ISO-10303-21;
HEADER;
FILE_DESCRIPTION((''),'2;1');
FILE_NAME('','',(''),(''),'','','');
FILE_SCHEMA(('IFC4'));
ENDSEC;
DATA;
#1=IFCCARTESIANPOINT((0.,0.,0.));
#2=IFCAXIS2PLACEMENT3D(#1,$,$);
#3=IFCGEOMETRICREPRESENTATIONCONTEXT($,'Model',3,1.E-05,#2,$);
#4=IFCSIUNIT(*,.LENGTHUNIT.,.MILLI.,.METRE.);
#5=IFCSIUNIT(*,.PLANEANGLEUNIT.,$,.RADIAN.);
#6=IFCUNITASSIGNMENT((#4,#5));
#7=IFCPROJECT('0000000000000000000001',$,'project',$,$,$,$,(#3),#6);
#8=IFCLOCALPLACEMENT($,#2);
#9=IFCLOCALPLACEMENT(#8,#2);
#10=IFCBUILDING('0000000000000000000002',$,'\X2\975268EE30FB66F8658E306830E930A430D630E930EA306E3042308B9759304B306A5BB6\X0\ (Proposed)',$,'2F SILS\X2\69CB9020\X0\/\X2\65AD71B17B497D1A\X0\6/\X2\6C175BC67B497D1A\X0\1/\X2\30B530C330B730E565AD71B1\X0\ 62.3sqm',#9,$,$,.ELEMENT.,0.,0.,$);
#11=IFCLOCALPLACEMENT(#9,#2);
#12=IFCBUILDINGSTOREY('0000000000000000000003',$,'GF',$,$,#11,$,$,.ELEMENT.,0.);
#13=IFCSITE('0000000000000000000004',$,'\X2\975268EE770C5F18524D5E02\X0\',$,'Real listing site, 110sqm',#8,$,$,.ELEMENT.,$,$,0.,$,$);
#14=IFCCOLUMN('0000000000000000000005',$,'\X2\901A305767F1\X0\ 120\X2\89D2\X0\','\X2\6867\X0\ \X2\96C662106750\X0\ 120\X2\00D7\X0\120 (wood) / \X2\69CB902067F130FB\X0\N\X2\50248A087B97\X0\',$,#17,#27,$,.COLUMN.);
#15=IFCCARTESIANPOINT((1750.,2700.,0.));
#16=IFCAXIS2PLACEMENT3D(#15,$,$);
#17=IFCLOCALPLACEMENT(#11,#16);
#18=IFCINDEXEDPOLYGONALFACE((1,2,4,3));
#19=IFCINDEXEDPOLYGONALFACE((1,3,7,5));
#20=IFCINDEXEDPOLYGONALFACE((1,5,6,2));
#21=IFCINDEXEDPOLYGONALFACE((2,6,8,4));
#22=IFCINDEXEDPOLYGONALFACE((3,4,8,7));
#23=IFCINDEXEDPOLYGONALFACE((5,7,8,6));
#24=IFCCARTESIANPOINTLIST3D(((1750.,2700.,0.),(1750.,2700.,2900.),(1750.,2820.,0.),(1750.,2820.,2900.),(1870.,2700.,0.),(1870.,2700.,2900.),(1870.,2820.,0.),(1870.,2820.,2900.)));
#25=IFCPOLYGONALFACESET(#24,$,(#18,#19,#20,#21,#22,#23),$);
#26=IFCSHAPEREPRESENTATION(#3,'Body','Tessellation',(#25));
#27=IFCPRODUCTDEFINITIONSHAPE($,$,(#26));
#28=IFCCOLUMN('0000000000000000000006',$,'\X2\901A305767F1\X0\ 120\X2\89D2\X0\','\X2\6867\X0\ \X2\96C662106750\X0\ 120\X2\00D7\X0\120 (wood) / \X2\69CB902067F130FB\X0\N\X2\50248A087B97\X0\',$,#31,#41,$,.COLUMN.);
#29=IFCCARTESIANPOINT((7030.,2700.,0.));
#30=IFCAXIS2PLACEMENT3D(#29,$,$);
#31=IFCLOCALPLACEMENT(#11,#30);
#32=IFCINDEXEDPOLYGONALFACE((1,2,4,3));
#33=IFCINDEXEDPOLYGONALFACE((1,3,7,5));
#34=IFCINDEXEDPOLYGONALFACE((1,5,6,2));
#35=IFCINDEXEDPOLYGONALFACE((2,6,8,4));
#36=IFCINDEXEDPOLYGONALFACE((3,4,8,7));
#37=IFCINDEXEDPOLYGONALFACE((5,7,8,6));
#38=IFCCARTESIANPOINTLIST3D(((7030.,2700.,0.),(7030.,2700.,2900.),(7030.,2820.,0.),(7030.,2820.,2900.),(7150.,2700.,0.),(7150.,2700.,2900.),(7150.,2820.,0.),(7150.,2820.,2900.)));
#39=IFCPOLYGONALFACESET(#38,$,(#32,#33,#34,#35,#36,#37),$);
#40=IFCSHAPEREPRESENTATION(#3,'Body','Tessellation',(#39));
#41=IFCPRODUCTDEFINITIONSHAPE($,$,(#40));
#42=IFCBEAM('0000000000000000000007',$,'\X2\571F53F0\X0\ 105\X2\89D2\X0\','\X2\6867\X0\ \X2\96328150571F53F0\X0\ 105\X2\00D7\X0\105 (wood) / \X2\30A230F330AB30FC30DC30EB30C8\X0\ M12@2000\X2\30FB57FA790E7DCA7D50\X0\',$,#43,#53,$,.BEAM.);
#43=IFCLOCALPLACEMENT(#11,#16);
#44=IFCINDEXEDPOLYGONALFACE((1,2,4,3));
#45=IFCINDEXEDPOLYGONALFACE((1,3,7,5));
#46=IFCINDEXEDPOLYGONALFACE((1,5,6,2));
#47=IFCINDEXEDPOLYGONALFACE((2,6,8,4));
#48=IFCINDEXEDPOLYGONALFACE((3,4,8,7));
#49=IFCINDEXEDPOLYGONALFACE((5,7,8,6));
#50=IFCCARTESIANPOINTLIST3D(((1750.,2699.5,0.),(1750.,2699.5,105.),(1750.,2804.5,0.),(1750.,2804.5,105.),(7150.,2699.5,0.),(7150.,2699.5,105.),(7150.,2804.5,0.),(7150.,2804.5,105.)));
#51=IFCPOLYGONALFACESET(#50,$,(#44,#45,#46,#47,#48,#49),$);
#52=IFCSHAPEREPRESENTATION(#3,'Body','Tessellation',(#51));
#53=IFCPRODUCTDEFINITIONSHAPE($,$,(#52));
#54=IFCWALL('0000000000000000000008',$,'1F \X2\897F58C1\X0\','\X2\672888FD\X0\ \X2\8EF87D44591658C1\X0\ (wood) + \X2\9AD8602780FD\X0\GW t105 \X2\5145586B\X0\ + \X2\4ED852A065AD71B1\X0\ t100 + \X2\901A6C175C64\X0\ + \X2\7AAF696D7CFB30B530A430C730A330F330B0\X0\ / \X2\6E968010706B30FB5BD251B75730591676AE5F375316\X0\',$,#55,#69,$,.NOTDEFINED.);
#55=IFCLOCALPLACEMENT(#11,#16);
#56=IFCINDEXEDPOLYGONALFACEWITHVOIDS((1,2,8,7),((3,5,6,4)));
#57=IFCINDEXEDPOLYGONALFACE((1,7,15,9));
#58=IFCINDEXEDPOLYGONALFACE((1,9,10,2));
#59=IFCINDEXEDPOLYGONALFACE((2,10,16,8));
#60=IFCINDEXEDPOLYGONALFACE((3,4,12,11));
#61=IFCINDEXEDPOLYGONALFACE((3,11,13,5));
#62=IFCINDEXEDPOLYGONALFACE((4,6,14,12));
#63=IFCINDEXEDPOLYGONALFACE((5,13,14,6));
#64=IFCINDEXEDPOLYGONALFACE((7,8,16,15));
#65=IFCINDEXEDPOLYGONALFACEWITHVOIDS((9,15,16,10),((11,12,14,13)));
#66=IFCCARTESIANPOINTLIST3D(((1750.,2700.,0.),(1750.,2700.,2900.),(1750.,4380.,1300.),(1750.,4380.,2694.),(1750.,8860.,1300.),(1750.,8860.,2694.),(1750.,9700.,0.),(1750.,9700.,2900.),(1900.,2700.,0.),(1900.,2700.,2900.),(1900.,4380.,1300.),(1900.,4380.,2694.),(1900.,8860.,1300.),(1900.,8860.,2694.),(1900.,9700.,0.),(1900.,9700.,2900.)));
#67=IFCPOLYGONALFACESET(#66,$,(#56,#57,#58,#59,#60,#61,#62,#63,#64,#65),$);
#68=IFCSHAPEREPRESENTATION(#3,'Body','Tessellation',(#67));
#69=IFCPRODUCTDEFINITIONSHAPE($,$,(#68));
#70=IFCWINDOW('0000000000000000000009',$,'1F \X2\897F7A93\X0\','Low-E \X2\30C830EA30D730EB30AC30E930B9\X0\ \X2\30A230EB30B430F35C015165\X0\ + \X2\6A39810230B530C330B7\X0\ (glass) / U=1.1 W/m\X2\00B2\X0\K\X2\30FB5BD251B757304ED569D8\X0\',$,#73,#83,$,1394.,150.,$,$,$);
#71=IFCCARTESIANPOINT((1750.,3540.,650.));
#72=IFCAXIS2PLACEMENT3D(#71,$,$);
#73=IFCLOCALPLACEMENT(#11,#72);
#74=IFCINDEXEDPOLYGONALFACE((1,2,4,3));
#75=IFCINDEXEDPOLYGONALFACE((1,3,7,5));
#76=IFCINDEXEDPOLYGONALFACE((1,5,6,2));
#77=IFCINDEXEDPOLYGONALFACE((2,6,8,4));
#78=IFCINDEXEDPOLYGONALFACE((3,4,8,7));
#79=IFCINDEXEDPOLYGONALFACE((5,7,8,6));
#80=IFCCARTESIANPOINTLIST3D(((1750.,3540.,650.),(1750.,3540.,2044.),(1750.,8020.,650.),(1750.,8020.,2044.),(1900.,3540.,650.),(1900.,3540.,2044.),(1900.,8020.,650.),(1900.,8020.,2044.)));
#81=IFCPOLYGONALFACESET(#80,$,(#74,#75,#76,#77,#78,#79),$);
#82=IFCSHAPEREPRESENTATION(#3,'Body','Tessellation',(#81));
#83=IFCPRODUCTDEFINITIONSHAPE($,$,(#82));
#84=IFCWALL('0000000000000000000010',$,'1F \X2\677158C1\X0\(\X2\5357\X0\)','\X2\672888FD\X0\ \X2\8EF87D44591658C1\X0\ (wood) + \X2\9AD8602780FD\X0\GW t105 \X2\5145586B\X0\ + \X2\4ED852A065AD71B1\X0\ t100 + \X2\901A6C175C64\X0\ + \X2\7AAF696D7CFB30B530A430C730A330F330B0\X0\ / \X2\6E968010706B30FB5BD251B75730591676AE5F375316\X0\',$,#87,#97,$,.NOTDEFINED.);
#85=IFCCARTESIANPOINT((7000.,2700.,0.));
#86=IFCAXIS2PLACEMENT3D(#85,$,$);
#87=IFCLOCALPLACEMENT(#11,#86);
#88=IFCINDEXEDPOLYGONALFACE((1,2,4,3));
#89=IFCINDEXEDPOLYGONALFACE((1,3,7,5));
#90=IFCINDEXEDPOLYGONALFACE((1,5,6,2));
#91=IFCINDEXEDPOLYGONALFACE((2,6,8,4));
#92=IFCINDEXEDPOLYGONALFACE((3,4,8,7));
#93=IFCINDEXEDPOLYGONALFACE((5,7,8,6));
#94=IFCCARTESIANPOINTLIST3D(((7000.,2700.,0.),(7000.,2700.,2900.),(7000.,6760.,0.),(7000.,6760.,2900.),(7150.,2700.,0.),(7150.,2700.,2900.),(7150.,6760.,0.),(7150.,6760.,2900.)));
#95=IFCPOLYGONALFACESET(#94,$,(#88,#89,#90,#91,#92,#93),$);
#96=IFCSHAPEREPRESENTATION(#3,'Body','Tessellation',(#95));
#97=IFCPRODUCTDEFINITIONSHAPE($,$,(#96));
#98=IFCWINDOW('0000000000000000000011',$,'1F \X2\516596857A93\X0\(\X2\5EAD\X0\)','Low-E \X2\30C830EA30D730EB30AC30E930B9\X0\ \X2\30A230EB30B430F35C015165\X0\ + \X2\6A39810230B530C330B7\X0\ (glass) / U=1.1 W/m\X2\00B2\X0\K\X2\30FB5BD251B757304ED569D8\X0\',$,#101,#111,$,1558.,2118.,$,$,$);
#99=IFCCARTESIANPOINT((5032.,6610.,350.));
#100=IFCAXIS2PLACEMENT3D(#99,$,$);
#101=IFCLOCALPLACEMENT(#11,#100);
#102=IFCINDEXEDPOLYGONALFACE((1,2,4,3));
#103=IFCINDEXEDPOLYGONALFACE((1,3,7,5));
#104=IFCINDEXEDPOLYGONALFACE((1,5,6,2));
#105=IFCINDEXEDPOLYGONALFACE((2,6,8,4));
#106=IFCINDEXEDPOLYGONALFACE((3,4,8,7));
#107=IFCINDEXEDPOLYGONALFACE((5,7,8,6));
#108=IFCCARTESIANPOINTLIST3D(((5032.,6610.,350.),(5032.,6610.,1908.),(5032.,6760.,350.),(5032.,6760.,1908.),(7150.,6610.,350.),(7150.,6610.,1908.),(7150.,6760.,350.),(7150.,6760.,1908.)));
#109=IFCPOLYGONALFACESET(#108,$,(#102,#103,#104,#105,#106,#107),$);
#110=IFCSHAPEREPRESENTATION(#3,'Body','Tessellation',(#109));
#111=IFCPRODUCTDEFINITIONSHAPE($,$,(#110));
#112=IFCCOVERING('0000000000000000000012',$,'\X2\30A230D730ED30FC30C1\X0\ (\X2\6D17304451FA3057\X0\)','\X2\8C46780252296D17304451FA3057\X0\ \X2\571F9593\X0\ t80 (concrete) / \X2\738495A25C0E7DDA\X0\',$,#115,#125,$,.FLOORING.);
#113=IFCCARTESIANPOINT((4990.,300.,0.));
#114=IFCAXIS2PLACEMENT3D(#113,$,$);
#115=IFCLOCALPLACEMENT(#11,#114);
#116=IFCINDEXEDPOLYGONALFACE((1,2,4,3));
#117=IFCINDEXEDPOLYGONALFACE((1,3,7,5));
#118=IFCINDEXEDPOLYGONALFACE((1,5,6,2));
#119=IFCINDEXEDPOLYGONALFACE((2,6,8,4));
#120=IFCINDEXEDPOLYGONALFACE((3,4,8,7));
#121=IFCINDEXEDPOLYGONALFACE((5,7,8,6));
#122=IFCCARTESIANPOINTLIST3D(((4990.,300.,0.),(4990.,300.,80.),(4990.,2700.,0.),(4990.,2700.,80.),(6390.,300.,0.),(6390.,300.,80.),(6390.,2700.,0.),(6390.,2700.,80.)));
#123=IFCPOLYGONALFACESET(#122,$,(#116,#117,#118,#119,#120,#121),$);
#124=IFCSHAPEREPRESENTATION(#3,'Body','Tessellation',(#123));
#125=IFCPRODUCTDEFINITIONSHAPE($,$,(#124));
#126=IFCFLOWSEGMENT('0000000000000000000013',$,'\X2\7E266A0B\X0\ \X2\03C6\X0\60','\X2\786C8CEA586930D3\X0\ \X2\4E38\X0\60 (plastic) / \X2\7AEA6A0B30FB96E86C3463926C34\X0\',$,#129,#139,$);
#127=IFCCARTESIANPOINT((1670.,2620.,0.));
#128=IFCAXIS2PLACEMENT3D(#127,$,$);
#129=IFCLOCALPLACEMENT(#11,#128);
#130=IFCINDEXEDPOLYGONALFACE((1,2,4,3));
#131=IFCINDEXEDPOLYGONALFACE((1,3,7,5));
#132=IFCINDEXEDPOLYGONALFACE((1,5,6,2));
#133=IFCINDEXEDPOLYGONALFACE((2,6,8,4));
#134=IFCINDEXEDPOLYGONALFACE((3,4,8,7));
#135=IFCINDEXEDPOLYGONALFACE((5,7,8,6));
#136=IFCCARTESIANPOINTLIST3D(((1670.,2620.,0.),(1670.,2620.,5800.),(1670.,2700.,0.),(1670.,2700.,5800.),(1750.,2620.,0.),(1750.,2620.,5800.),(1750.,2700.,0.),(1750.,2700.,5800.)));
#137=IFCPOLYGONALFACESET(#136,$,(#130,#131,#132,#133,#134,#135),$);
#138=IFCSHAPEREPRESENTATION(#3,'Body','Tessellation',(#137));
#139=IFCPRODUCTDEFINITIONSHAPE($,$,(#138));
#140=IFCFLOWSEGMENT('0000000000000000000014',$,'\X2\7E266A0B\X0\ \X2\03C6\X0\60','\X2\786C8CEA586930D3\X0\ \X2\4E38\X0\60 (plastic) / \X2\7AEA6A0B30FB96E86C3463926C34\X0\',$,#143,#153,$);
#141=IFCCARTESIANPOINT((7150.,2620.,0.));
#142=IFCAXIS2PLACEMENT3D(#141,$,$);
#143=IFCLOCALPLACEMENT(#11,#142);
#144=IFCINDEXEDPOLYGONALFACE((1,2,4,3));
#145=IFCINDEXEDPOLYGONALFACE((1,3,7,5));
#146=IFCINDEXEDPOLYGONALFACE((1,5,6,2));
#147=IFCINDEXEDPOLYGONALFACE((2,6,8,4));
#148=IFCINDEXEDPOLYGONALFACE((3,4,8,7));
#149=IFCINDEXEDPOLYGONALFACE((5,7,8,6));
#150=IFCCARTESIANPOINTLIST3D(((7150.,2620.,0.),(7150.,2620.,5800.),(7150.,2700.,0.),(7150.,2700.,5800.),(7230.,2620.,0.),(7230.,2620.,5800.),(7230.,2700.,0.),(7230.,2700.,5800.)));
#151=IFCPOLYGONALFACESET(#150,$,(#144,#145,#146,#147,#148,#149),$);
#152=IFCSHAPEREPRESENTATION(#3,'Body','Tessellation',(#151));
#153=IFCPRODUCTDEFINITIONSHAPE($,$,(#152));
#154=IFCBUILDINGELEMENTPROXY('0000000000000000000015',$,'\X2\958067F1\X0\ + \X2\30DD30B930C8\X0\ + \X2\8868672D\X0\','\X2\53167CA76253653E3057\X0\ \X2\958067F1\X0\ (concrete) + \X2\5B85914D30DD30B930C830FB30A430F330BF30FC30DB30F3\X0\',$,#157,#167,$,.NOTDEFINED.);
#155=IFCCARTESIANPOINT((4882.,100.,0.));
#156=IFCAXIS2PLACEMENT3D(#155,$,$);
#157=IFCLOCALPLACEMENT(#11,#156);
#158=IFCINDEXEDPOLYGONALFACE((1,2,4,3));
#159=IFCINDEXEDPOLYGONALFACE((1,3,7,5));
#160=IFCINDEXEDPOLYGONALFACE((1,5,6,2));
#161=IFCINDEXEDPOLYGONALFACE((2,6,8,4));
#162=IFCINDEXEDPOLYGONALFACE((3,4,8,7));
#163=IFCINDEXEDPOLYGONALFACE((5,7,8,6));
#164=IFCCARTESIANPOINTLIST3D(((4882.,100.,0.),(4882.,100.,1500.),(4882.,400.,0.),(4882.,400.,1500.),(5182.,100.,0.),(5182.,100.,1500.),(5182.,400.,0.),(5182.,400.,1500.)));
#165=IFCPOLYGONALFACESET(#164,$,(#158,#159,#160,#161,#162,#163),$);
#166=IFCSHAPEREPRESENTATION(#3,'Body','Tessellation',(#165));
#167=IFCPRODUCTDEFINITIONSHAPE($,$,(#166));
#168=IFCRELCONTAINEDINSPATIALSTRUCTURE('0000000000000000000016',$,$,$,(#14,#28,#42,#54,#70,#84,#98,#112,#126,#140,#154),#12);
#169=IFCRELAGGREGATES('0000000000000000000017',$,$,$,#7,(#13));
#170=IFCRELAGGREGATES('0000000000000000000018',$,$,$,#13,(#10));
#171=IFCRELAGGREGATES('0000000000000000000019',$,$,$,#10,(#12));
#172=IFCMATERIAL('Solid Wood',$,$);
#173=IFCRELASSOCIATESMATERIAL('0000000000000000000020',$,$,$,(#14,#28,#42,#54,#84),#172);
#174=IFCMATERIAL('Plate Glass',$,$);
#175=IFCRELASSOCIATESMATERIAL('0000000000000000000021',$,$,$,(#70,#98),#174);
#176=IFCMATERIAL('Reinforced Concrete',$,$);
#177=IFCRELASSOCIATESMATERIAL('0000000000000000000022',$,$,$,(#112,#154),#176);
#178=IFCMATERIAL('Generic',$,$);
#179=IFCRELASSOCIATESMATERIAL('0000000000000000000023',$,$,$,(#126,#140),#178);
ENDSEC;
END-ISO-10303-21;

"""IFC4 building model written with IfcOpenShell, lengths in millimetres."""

from ifc_helpers import new_model, si_unit, frame, frame_2d, origin, place, context, project, spatial, rectangle, extrude, material, element, fill, save


model = new_model("IFC4")

# Units and contexts
model_context = context("Model", 3, precision=1e-05, world=origin())
ifc_project = project(units=[si_unit("LENGTHUNIT", "METRE", prefix="MILLI"), si_unit("PLANEANGLEUNIT", "RADIAN")], contexts=[model_context])

# Site, building, storey
site_placement = place(None, origin())
site = spatial("IfcSite", under=ifc_project, at=site_placement, Name="青森県弘前市", ObjectType="Real listing site, 110sqm", CompositionType="ELEMENT", RefElevation=0.0)
building_placement = place(site_placement, origin())
building = spatial("IfcBuilding", under=site, at=building_placement, Name="青森・書斎とライブラリのある静かな家 (Proposed)", ObjectType="2F SILS構造/断熱等級6/気密等級1/サッシュ断熱 62.3sqm", CompositionType="ELEMENT", ElevationOfRefHeight=0.0, ElevationOfTerrain=0.0)
storey_placement = place(building_placement, origin())
storey = spatial("IfcBuildingStorey", under=building, at=storey_placement, Name="GF", CompositionType="ELEMENT", Elevation=0.0)

# Columns
ifc_material_1 = material(Name="Solid Wood")
column_1_placement = place(storey_placement, frame((1750.0, 2700.0, 0.0)))
element("IfcColumn", 1, at=column_1_placement, inside=storey, material=ifc_material_1, Name="通し柱 120角", Description="桧 集成材 120×120 (wood) / 構造柱・N値計算", PredefinedType="COLUMN", context=model_context, shape_type="SweptSolid", body=[
    extrude(rectangle(XDim=120.0, YDim=120.0, at=frame_2d((60.0, 60.0))), frame((1750.0, 2700.0, 0.0)), (0.0, 0.0, 1.0), 2900.0),
])
column_2_placement = place(storey_placement, frame((7030.0, 2700.0, 0.0)))
element("IfcColumn", 2, at=column_2_placement, inside=storey, material=ifc_material_1, Name="通し柱 120角", Description="桧 集成材 120×120 (wood) / 構造柱・N値計算", PredefinedType="COLUMN", context=model_context, shape_type="SweptSolid", body=[
    extrude(rectangle(XDim=120.0, YDim=120.0, at=frame_2d((60.0, 60.0))), frame((7030.0, 2700.0, 0.0)), (0.0, 0.0, 1.0), 2900.0),
])

# Beam
beam_1_placement = place(storey_placement, frame((1750.0, 2700.0, 0.0)))
element("IfcBeam", 3, at=beam_1_placement, inside=storey, material=ifc_material_1, Name="土台 105角", Description="桧 防腐土台 105×105 (wood) / アンカーボルト M12@2000・基礎緊結", PredefinedType="BEAM", context=model_context, shape_type="SweptSolid", body=[
    extrude(rectangle(XDim=5400.0, YDim=105.0, at=frame_2d((2700.0, 52.0))), frame((1750.0, 2700.0, 0.0)), (0.0, 0.0, 1.0), 105.0),
])

# Shared definitions
ifc_material_2 = material(Name="Reinforced Concrete")

# Shared definitions
ifc_material_3 = material(Name="Plate Glass")

# Walls, openings, windows
wall_1_placement = place(storey_placement, frame((1750.0, 2700.0, 0.0)))
wall_1 = element("IfcWall", 4, at=wall_1_placement, inside=storey, material=ifc_material_1, Name="1F 西壁", Description="木製 軸組外壁 (wood) + 高性能GW t105 充填 + 付加断熱 t100 + 通気層 + 窯業系サイディング / 準耐火・寒冷地外皮強化", PredefinedType="NOTDEFINED", context=model_context, shape_type="SweptSolid", body=[
    extrude(rectangle(XDim=150.0, YDim=7000.0, at=frame_2d((75.0, 3500.0))), frame((1750.0, 2700.0, 0.0)), (0.0, 0.0, 1.0), 2900.0),
])
opening_1_placement = place(storey_placement, frame((1750.0, 3540.0, 650.0)))
opening_1 = element("IfcOpeningElement", 5, at=opening_1_placement, cuts=wall_1, PredefinedType="NOTDEFINED", context=model_context, shape_type="SweptSolid", body=[
    extrude(rectangle(XDim=150.0, YDim=4480.0, at=frame_2d((75.0, 2240.0))), frame((1750.0, 3540.0, 650.0)), (0.0, 0.0, 1.0), 1394.0),
])
window_1_placement = place(storey_placement, frame((1750.0, 3540.0, 650.0)))
window_1 = element("IfcWindow", 6, at=window_1_placement, inside=storey, material=ifc_material_3, Name="1F 西窓", Description="Low-E トリプルガラス アルゴン封入 + 樹脂サッシ (glass) / U=1.1 W/m²K・寒冷地仕様", OverallHeight=1394.0, OverallWidth=150.0, context=model_context, shape_type="SweptSolid", body=[
    extrude(rectangle(XDim=150.0, YDim=4480.0, at=frame_2d((75.0, 2240.0))), frame((1750.0, 3540.0, 650.0)), (0.0, 0.0, 1.0), 1394.0),
])
fill(opening_1, window_1)
wall_2_placement = place(storey_placement, frame((7000.0, 2700.0, 0.0)))
wall_2 = element("IfcWall", 7, at=wall_2_placement, inside=storey, material=ifc_material_1, Name="1F 東壁(南)", Description="木製 軸組外壁 (wood) + 高性能GW t105 充填 + 付加断熱 t100 + 通気層 + 窯業系サイディング / 準耐火・寒冷地外皮強化", PredefinedType="NOTDEFINED", context=model_context, shape_type="SweptSolid", body=[
    extrude(rectangle(XDim=150.0, YDim=4060.0, at=frame_2d((75.0, 2030.0))), frame((7000.0, 2700.0, 0.0)), (0.0, 0.0, 1.0), 2900.0),
])
opening_2_placement = place(storey_placement, frame((5032.0, 6610.0, 350.0)))
opening_2 = element("IfcOpeningElement", 8, at=opening_2_placement, cuts=wall_2, PredefinedType="NOTDEFINED", context=model_context, shape_type="SweptSolid", body=[
    extrude(rectangle(XDim=2118.0, YDim=150.0, at=frame_2d((1059.0, 75.0))), frame((5032.0, 6610.0, 350.0)), (0.0, 0.0, 1.0), 1558.0),
])
window_2_placement = place(storey_placement, frame((5032.0, 6610.0, 350.0)))
window_2 = element("IfcWindow", 9, at=window_2_placement, inside=storey, material=ifc_material_3, Name="1F 入隅窓(庭)", Description="Low-E トリプルガラス アルゴン封入 + 樹脂サッシ (glass) / U=1.1 W/m²K・寒冷地仕様", OverallHeight=1558.0, OverallWidth=2118.0, context=model_context, shape_type="SweptSolid", body=[
    extrude(rectangle(XDim=2118.0, YDim=150.0, at=frame_2d((1059.0, 75.0))), frame((5032.0, 6610.0, 350.0)), (0.0, 0.0, 1.0), 1558.0),
])
fill(opening_2, window_2)

# Covering
covering_1_placement = place(storey_placement, frame((4990.0, 300.0, 0.0)))
element("IfcCovering", 10, at=covering_1_placement, inside=storey, material=ifc_material_2, Name="アプローチ (洗い出し)", Description="豆砂利洗い出し 土間 t80 (concrete) / 玄関導線", PredefinedType="FLOORING", context=model_context, shape_type="SweptSolid", body=[
    extrude(rectangle(XDim=1400.0, YDim=2400.0, at=frame_2d((700.0, 1200.0))), frame((4990.0, 300.0, 0.0)), (0.0, 0.0, 1.0), 80.0),
])

# Flow segments
ifc_material_4 = material(Name="Generic")
flow_segment_1_placement = place(storey_placement, frame((1670.0, 2620.0, 0.0)))
element("IfcFlowSegment", 11, at=flow_segment_1_placement, inside=storey, material=ifc_material_4, Name="縦樋 φ60", Description="硬質塩ビ 丸60 (plastic) / 竪樋・雨水排水", context=model_context, shape_type="SweptSolid", body=[
    extrude(rectangle(XDim=80.0, YDim=80.0, at=frame_2d((40.0, 40.0))), frame((1670.0, 2620.0, 0.0)), (0.0, 0.0, 1.0), 5800.0),
])
flow_segment_2_placement = place(storey_placement, frame((7150.0, 2620.0, 0.0)))
element("IfcFlowSegment", 12, at=flow_segment_2_placement, inside=storey, material=ifc_material_4, Name="縦樋 φ60", Description="硬質塩ビ 丸60 (plastic) / 竪樋・雨水排水", context=model_context, shape_type="SweptSolid", body=[
    extrude(rectangle(XDim=80.0, YDim=80.0, at=frame_2d((40.0, 40.0))), frame((7150.0, 2620.0, 0.0)), (0.0, 0.0, 1.0), 5800.0),
])

# Building element proxy
proxy_placement = place(storey_placement, frame((4882.0, 100.0, 0.0)))
element("IfcBuildingElementProxy", 13, at=proxy_placement, inside=storey, material=ifc_material_2, Name="門柱 + ポスト + 表札", Description="化粧打放し 門柱 (concrete) + 宅配ポスト・インターホン", PredefinedType="NOTDEFINED", context=model_context, shape_type="SweptSolid", body=[
    extrude(rectangle(XDim=300.0, YDim=300.0, at=frame_2d((150.0, 150.0))), frame((4882.0, 100.0, 0.0)), (0.0, 0.0, 1.0), 1500.0),
])

save(model, "model.ifc")
